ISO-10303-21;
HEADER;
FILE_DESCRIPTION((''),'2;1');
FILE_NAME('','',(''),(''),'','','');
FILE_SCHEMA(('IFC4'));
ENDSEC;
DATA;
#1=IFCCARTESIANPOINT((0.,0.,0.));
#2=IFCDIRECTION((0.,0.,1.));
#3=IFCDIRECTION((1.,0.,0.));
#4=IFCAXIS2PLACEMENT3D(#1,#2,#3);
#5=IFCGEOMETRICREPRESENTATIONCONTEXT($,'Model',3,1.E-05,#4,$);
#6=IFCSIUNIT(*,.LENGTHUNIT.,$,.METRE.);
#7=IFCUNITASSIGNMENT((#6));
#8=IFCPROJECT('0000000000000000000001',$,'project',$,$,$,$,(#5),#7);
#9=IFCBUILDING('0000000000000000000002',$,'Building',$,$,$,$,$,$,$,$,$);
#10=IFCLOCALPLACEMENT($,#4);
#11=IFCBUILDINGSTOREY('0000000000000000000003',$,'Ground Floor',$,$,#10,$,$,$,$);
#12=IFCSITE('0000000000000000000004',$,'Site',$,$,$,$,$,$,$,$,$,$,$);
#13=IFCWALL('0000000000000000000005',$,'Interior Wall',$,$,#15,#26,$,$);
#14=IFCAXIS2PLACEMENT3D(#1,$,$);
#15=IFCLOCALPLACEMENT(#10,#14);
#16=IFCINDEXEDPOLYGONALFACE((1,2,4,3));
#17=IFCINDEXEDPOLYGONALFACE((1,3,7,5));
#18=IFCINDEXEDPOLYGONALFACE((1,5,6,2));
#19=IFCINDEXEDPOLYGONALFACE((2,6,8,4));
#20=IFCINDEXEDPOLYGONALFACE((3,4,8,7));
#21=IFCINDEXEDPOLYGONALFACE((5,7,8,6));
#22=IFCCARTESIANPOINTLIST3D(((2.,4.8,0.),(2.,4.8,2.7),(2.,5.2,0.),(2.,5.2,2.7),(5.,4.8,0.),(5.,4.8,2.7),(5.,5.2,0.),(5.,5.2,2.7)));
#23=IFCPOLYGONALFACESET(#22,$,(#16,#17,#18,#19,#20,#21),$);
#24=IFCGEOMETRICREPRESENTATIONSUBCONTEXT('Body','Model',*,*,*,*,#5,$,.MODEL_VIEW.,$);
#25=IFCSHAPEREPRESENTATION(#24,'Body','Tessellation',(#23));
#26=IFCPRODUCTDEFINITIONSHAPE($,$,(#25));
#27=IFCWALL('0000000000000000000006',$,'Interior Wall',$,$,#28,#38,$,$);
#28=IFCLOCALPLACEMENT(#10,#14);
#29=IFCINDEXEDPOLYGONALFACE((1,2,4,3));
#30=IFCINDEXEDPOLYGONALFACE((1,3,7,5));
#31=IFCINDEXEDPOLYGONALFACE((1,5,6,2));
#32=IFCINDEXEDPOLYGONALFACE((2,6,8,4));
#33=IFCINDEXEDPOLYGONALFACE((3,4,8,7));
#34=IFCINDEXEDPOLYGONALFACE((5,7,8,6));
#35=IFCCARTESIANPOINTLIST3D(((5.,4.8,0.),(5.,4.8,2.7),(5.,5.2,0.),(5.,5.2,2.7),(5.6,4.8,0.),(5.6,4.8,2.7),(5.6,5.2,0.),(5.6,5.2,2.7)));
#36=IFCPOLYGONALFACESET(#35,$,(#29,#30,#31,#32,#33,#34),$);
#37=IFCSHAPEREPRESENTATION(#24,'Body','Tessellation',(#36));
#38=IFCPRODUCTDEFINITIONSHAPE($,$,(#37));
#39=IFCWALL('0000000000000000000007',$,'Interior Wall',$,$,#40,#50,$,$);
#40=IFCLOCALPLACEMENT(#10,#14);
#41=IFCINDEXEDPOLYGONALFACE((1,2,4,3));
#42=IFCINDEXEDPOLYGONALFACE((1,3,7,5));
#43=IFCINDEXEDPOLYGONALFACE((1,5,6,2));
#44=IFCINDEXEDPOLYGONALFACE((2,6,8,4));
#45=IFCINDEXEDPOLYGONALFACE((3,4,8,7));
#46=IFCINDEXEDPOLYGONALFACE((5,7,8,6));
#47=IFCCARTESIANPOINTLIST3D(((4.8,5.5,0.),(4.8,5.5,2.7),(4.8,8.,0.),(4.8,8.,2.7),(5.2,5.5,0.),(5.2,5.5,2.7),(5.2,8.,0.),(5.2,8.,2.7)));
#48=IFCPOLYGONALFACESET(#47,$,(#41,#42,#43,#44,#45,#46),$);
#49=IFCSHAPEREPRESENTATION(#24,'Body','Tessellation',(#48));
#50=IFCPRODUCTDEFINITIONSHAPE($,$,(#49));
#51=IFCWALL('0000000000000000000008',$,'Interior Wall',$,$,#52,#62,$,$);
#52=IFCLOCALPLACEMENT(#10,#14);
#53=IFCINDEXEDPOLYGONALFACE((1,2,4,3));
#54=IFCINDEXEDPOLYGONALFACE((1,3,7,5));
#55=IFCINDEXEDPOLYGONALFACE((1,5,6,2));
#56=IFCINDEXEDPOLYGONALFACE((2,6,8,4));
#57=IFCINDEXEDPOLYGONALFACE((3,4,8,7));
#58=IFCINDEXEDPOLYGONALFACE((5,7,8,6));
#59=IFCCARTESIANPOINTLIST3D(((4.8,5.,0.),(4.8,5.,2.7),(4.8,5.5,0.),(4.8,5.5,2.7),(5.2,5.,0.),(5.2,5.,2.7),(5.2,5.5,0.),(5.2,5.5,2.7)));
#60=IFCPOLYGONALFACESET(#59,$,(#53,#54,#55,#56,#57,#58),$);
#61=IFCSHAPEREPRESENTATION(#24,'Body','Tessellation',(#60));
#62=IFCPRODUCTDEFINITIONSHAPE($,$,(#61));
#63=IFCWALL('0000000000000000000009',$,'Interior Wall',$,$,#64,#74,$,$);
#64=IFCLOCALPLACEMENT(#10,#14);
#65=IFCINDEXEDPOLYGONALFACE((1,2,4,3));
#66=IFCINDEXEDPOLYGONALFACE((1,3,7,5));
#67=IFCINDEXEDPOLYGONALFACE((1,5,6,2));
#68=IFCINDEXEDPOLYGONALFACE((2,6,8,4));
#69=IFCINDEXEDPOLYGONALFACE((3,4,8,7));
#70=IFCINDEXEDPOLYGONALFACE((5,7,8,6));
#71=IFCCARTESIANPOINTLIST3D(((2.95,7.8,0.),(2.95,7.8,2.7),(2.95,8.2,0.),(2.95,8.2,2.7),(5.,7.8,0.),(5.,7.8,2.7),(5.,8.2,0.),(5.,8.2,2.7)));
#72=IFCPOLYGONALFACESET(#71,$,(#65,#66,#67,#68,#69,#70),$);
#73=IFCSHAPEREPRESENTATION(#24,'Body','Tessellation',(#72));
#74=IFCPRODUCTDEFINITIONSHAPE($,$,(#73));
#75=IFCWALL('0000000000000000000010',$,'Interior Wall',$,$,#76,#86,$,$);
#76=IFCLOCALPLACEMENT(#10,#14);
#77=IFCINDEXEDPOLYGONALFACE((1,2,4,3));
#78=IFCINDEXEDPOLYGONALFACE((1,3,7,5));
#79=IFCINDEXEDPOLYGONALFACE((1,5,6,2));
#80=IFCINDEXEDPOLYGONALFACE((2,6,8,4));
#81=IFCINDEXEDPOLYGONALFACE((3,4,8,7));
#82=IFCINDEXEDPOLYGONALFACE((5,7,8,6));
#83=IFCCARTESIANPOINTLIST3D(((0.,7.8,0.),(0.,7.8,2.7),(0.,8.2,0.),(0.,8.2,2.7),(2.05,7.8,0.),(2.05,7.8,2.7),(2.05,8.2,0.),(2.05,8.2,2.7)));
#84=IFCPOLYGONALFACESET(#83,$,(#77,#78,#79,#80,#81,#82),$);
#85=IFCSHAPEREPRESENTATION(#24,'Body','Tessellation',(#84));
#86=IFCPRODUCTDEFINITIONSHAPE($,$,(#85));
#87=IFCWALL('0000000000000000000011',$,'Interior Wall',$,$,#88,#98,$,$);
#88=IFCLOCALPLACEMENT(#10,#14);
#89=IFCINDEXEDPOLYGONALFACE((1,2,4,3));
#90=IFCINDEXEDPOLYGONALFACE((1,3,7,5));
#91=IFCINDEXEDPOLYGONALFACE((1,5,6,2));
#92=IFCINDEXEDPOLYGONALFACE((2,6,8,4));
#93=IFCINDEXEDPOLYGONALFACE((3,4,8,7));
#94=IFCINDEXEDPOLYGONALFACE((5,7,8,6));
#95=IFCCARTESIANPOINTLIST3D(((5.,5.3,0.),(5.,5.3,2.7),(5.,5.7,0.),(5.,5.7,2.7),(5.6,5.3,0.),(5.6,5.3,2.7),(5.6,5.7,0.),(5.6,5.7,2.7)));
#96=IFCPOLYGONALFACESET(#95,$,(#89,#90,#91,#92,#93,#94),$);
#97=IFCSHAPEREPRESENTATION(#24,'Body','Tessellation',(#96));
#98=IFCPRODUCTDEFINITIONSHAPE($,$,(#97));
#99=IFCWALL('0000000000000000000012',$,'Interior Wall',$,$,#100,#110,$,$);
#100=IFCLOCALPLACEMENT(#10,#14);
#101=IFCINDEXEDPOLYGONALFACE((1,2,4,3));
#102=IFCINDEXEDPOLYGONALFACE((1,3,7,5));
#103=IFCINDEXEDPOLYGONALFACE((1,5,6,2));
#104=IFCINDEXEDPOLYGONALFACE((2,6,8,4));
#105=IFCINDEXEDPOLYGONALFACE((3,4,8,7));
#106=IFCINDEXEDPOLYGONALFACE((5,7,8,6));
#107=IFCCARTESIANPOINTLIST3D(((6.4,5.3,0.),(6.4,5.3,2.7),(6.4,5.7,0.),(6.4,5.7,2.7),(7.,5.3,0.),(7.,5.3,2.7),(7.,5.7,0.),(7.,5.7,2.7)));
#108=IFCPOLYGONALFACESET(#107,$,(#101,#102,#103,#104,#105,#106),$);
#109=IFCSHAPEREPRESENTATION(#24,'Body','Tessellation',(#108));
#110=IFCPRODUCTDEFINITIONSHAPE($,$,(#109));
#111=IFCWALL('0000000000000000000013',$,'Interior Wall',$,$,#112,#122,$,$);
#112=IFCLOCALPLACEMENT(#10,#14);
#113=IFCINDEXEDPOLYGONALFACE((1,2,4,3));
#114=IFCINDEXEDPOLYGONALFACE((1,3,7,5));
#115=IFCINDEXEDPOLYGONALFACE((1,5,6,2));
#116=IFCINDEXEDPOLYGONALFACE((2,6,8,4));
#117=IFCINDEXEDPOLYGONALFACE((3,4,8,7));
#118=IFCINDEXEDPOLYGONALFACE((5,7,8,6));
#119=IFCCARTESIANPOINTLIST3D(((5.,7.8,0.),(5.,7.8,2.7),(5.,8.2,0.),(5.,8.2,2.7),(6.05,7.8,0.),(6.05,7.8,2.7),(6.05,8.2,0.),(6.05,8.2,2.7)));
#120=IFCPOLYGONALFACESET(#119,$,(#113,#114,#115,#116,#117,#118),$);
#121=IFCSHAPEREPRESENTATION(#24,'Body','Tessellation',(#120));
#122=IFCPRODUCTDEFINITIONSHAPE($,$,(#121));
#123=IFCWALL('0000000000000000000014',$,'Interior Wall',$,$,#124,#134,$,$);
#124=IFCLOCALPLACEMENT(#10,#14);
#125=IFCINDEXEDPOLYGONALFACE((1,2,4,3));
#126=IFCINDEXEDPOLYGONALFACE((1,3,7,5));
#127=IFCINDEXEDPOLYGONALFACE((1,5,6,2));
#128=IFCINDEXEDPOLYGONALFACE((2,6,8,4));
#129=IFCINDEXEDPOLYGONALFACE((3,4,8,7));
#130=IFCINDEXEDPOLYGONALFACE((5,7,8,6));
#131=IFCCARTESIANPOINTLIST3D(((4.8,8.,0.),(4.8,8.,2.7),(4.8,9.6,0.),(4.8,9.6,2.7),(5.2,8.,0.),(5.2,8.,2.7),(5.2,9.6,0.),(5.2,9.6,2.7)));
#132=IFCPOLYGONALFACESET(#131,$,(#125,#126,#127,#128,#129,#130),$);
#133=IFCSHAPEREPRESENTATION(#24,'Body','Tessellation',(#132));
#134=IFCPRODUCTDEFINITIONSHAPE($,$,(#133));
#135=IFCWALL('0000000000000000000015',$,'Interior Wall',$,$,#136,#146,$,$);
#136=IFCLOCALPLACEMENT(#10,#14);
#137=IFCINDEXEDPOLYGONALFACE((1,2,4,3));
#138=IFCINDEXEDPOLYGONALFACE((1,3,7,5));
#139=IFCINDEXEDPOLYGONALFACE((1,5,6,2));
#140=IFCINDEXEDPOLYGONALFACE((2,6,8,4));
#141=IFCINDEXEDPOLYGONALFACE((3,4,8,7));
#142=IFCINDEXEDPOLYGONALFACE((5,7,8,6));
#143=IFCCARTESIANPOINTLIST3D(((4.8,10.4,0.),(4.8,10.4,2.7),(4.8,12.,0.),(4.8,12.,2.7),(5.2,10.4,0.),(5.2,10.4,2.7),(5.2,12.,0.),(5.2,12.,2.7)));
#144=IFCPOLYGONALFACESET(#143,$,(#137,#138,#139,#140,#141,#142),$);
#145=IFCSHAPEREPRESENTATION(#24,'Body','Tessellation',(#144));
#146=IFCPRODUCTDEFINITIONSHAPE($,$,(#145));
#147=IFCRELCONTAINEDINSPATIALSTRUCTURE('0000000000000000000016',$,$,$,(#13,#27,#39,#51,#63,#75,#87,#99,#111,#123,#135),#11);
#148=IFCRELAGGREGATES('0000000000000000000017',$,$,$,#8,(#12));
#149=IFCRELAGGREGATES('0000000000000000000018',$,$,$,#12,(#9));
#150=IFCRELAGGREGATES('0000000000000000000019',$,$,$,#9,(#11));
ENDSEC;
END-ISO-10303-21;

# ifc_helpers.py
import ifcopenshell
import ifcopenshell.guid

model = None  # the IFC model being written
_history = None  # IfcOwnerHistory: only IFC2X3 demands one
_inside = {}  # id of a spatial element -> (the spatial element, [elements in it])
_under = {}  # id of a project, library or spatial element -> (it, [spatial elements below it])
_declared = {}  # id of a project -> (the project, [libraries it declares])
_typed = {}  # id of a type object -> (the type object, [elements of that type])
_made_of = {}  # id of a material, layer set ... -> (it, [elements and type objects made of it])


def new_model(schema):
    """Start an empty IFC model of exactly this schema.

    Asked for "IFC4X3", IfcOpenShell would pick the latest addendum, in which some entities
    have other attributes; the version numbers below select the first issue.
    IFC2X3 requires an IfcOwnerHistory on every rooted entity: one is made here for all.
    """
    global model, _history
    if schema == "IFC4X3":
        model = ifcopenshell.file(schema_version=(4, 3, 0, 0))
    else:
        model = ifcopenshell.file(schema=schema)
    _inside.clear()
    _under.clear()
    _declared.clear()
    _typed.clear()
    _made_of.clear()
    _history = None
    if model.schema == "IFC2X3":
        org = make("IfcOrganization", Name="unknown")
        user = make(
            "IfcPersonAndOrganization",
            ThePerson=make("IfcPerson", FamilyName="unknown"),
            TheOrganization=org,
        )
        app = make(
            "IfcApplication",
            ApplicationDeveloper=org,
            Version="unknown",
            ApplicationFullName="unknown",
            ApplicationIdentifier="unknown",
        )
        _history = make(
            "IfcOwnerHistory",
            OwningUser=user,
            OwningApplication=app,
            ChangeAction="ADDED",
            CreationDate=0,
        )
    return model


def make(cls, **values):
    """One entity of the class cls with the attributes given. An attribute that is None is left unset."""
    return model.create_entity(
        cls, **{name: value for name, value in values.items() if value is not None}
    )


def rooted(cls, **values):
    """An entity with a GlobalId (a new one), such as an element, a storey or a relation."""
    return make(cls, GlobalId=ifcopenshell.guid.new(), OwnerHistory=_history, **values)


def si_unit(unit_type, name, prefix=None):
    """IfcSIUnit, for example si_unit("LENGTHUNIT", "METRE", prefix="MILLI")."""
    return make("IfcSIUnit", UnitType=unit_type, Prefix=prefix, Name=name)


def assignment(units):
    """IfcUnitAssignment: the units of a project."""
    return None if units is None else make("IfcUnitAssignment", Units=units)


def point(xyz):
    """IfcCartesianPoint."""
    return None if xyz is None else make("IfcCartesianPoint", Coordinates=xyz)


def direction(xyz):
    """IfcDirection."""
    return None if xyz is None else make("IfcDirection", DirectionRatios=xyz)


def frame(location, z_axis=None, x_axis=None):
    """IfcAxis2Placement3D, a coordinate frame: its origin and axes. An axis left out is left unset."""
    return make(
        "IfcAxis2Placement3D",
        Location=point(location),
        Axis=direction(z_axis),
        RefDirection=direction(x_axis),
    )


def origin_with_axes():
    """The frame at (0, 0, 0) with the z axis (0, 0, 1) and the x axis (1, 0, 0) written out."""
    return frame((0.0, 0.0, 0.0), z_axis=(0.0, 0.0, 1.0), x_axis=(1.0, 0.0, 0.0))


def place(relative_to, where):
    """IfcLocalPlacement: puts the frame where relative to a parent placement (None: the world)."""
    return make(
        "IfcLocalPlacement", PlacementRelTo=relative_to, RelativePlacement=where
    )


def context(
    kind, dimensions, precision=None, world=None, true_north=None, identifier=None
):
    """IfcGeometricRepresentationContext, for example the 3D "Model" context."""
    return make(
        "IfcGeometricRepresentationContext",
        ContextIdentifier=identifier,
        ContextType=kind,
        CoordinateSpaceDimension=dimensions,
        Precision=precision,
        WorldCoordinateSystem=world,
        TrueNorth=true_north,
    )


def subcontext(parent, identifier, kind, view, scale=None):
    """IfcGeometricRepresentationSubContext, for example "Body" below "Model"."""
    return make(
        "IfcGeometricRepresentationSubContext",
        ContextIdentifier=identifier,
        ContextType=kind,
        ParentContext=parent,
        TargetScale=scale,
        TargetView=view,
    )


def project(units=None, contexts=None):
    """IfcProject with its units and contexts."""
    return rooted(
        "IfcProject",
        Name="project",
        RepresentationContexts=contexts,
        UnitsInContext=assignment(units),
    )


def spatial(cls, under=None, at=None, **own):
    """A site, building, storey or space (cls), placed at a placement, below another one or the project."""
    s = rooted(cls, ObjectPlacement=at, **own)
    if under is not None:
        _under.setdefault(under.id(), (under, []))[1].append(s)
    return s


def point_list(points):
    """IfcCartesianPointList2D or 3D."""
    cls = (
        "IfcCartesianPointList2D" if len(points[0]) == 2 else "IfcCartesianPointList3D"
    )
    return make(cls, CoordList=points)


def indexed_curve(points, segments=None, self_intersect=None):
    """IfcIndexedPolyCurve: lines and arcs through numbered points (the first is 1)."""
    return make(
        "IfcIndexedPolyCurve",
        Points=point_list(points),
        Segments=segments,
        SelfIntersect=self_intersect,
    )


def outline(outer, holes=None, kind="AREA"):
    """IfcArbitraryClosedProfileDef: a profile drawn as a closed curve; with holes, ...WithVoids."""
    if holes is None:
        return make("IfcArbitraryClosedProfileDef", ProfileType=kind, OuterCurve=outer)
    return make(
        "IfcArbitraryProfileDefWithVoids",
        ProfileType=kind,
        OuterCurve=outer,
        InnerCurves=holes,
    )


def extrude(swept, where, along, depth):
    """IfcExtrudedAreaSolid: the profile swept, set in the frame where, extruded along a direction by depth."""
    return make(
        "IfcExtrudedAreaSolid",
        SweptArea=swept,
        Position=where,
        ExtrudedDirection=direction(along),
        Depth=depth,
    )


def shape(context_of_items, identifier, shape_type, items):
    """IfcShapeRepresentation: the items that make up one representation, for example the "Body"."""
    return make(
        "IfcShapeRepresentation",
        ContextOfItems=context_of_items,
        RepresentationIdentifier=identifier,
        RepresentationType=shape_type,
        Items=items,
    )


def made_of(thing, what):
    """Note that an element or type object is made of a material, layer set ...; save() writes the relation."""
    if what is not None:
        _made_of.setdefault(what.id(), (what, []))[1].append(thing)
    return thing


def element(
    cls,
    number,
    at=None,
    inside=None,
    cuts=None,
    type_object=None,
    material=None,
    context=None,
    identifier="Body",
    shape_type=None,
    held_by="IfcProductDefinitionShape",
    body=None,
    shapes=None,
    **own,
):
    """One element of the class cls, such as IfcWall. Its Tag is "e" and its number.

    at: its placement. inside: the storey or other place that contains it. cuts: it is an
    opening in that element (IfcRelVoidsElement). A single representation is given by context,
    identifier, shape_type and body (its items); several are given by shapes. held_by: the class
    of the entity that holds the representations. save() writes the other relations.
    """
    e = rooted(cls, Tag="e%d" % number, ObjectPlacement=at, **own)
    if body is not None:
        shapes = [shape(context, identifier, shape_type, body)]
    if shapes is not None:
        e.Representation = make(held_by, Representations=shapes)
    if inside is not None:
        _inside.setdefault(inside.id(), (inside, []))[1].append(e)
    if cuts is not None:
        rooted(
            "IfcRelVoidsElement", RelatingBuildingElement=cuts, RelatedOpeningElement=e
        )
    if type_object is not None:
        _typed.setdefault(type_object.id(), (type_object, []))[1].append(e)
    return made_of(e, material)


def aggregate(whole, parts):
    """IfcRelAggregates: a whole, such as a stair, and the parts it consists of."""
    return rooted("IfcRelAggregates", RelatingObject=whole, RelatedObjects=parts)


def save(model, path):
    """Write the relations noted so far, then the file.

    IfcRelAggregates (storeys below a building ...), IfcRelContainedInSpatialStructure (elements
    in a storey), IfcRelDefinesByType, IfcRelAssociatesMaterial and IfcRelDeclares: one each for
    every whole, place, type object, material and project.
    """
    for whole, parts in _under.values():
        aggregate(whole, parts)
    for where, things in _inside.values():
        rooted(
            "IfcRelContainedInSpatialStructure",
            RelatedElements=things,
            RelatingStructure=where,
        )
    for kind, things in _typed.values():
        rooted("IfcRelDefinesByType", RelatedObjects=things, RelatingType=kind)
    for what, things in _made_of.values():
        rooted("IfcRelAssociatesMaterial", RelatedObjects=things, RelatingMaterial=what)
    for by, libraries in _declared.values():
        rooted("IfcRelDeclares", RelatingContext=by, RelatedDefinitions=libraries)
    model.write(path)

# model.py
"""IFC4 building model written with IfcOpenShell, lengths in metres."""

from ifc_helpers import new_model, si_unit, frame, origin_with_axes, place, context, subcontext, project, spatial, indexed_curve, outline, extrude, element, save


model = new_model("IFC4")

# Units and contexts
model_context = context("Model", 3, precision=1e-05, world=origin_with_axes())
body_context = subcontext(model_context, "Body", "Model", "MODEL_VIEW")
ifc_project = project(units=[si_unit("LENGTHUNIT", "METRE")], contexts=[model_context])

# Site, building, storey
site = spatial("IfcSite", under=ifc_project, Name="Site")
building = spatial("IfcBuilding", under=site, Name="Building")
storey_placement = place(None, origin_with_axes())
storey = spatial("IfcBuildingStorey", under=building, at=storey_placement, Name="Ground Floor")

# Walls
wall_1_placement = place(storey_placement, frame((5.0, 5.0, 0.0), z_axis=(0.0, 0.0, 1.0), x_axis=(-1.0, 0.0, 0.0)))
element("IfcWall", 1, at=wall_1_placement, inside=storey, Name="Interior Wall", context=body_context, shape_type="SweptSolid", body=[
    extrude(outline(indexed_curve([(0.0, 0.0), (0.0, 0.4), (3.0, 0.4), (3.0, 0.0), (0.0, 0.0)], self_intersect=False)), frame((0.0, -0.2, 0.0), z_axis=(0.0, 0.0, 1.0), x_axis=(1.0, 0.0, 0.0)), (0.0, 0.0, 1.0), 2.7),
])
wall_2_placement = place(storey_placement, frame((5.6, 5.0, 0.0), z_axis=(0.0, 0.0, 1.0), x_axis=(-1.0, 0.0, 0.0)))
element("IfcWall", 2, at=wall_2_placement, inside=storey, Name="Interior Wall", context=body_context, shape_type="SweptSolid", body=[
    extrude(outline(indexed_curve([(0.0, 0.0), (0.0, 0.4), (0.6, 0.4), (0.6, 0.0), (0.0, 0.0)], self_intersect=False)), frame((0.0, -0.2, 0.0), z_axis=(0.0, 0.0, 1.0), x_axis=(1.0, 0.0, 0.0)), (0.0, 0.0, 1.0), 2.7),
])
wall_3_placement = place(storey_placement, frame((5.0, 5.5, 0.0), z_axis=(0.0, 0.0, 1.0), x_axis=(0.0, 1.0, 0.0)))
element("IfcWall", 3, at=wall_3_placement, inside=storey, Name="Interior Wall", context=body_context, shape_type="SweptSolid", body=[
    extrude(outline(indexed_curve([(0.0, 0.0), (0.0, 0.4), (2.5, 0.4), (2.5, 0.0), (0.0, 0.0)], self_intersect=False)), frame((0.0, -0.2, 0.0), z_axis=(0.0, 0.0, 1.0), x_axis=(1.0, 0.0, 0.0)), (0.0, 0.0, 1.0), 2.7),
])
wall_4_placement = place(storey_placement, frame((5.0, 5.0, 0.0), z_axis=(0.0, 0.0, 1.0), x_axis=(0.0, 1.0, 0.0)))
element("IfcWall", 4, at=wall_4_placement, inside=storey, Name="Interior Wall", context=body_context, shape_type="SweptSolid", body=[
    extrude(outline(indexed_curve([(0.0, 0.0), (0.0, 0.4), (0.5, 0.4), (0.5, 0.0), (0.0, 0.0)], self_intersect=False)), frame((0.0, -0.2, 0.0), z_axis=(0.0, 0.0, 1.0), x_axis=(1.0, 0.0, 0.0)), (0.0, 0.0, 1.0), 2.7),
])
for number, where, z_axis, x_axis, name in (
    (5, (5.0, 8.0, 0.0), (0.0, 0.0, 1.0), (-1.0, 0.0, 0.0), "Interior Wall"),
    (6, (2.05, 8.0, 0.0), (0.0, 0.0, 1.0), (-1.0, 0.0, 0.0), "Interior Wall"),
):
    element("IfcWall", number, at=place(storey_placement, frame(where, z_axis=z_axis, x_axis=x_axis)), inside=storey, Name=name, context=body_context, shape_type="SweptSolid", body=[
        extrude(outline(indexed_curve([(0.0, 0.0), (0.0, 0.4), (2.05, 0.4), (2.05, 0.0), (0.0, 0.0)], self_intersect=False)), frame((0.0, -0.2, 0.0), z_axis=(0.0, 0.0, 1.0), x_axis=(1.0, 0.0, 0.0)), (0.0, 0.0, 1.0), 2.7),
    ])
for number, where, z_axis, x_axis, name in (
    (7, (5.0, 5.5, 0.0), (0.0, 0.0, 1.0), (1.0, 0.0, 0.0), "Interior Wall"),
    (8, (6.4, 5.5, 0.0), (0.0, 0.0, 1.0), (1.0, 0.0, 0.0), "Interior Wall"),
):
    element("IfcWall", number, at=place(storey_placement, frame(where, z_axis=z_axis, x_axis=x_axis)), inside=storey, Name=name, context=body_context, shape_type="SweptSolid", body=[
        extrude(outline(indexed_curve([(0.0, 0.0), (0.0, 0.4), (0.6, 0.4), (0.6, 0.0), (0.0, 0.0)], self_intersect=False)), frame((0.0, -0.2, 0.0), z_axis=(0.0, 0.0, 1.0), x_axis=(1.0, 0.0, 0.0)), (0.0, 0.0, 1.0), 2.7),
    ])
wall_5_placement = place(storey_placement, frame((6.05, 8.0, 0.0), z_axis=(0.0, 0.0, 1.0), x_axis=(-1.0, 0.0, 0.0)))
element("IfcWall", 9, at=wall_5_placement, inside=storey, Name="Interior Wall", context=body_context, shape_type="SweptSolid", body=[
    extrude(outline(indexed_curve([(0.0, 0.0), (0.0, 0.4), (1.05, 0.4), (1.05, 0.0), (0.0, 0.0)], self_intersect=False)), frame((0.0, -0.2, 0.0), z_axis=(0.0, 0.0, 1.0), x_axis=(1.0, 0.0, 0.0)), (0.0, 0.0, 1.0), 2.7),
])
for number, where, z_axis, x_axis, name in (
    (10, (5.0, 8.0, 0.0), (0.0, 0.0, 1.0), (0.0, 1.0, 0.0), "Interior Wall"),
    (11, (5.0, 10.4, 0.0), (0.0, 0.0, 1.0), (0.0, 1.0, 0.0), "Interior Wall"),
):
    element("IfcWall", number, at=place(storey_placement, frame(where, z_axis=z_axis, x_axis=x_axis)), inside=storey, Name=name, context=body_context, shape_type="SweptSolid", body=[
        extrude(outline(indexed_curve([(0.0, 0.0), (0.0, 0.4), (1.6, 0.4), (1.6, 0.0), (0.0, 0.0)], self_intersect=False)), frame((0.0, -0.2, 0.0), z_axis=(0.0, 0.0, 1.0), x_axis=(1.0, 0.0, 0.0)), (0.0, 0.0, 1.0), 2.7),
    ])

save(model, "model.ifc")
